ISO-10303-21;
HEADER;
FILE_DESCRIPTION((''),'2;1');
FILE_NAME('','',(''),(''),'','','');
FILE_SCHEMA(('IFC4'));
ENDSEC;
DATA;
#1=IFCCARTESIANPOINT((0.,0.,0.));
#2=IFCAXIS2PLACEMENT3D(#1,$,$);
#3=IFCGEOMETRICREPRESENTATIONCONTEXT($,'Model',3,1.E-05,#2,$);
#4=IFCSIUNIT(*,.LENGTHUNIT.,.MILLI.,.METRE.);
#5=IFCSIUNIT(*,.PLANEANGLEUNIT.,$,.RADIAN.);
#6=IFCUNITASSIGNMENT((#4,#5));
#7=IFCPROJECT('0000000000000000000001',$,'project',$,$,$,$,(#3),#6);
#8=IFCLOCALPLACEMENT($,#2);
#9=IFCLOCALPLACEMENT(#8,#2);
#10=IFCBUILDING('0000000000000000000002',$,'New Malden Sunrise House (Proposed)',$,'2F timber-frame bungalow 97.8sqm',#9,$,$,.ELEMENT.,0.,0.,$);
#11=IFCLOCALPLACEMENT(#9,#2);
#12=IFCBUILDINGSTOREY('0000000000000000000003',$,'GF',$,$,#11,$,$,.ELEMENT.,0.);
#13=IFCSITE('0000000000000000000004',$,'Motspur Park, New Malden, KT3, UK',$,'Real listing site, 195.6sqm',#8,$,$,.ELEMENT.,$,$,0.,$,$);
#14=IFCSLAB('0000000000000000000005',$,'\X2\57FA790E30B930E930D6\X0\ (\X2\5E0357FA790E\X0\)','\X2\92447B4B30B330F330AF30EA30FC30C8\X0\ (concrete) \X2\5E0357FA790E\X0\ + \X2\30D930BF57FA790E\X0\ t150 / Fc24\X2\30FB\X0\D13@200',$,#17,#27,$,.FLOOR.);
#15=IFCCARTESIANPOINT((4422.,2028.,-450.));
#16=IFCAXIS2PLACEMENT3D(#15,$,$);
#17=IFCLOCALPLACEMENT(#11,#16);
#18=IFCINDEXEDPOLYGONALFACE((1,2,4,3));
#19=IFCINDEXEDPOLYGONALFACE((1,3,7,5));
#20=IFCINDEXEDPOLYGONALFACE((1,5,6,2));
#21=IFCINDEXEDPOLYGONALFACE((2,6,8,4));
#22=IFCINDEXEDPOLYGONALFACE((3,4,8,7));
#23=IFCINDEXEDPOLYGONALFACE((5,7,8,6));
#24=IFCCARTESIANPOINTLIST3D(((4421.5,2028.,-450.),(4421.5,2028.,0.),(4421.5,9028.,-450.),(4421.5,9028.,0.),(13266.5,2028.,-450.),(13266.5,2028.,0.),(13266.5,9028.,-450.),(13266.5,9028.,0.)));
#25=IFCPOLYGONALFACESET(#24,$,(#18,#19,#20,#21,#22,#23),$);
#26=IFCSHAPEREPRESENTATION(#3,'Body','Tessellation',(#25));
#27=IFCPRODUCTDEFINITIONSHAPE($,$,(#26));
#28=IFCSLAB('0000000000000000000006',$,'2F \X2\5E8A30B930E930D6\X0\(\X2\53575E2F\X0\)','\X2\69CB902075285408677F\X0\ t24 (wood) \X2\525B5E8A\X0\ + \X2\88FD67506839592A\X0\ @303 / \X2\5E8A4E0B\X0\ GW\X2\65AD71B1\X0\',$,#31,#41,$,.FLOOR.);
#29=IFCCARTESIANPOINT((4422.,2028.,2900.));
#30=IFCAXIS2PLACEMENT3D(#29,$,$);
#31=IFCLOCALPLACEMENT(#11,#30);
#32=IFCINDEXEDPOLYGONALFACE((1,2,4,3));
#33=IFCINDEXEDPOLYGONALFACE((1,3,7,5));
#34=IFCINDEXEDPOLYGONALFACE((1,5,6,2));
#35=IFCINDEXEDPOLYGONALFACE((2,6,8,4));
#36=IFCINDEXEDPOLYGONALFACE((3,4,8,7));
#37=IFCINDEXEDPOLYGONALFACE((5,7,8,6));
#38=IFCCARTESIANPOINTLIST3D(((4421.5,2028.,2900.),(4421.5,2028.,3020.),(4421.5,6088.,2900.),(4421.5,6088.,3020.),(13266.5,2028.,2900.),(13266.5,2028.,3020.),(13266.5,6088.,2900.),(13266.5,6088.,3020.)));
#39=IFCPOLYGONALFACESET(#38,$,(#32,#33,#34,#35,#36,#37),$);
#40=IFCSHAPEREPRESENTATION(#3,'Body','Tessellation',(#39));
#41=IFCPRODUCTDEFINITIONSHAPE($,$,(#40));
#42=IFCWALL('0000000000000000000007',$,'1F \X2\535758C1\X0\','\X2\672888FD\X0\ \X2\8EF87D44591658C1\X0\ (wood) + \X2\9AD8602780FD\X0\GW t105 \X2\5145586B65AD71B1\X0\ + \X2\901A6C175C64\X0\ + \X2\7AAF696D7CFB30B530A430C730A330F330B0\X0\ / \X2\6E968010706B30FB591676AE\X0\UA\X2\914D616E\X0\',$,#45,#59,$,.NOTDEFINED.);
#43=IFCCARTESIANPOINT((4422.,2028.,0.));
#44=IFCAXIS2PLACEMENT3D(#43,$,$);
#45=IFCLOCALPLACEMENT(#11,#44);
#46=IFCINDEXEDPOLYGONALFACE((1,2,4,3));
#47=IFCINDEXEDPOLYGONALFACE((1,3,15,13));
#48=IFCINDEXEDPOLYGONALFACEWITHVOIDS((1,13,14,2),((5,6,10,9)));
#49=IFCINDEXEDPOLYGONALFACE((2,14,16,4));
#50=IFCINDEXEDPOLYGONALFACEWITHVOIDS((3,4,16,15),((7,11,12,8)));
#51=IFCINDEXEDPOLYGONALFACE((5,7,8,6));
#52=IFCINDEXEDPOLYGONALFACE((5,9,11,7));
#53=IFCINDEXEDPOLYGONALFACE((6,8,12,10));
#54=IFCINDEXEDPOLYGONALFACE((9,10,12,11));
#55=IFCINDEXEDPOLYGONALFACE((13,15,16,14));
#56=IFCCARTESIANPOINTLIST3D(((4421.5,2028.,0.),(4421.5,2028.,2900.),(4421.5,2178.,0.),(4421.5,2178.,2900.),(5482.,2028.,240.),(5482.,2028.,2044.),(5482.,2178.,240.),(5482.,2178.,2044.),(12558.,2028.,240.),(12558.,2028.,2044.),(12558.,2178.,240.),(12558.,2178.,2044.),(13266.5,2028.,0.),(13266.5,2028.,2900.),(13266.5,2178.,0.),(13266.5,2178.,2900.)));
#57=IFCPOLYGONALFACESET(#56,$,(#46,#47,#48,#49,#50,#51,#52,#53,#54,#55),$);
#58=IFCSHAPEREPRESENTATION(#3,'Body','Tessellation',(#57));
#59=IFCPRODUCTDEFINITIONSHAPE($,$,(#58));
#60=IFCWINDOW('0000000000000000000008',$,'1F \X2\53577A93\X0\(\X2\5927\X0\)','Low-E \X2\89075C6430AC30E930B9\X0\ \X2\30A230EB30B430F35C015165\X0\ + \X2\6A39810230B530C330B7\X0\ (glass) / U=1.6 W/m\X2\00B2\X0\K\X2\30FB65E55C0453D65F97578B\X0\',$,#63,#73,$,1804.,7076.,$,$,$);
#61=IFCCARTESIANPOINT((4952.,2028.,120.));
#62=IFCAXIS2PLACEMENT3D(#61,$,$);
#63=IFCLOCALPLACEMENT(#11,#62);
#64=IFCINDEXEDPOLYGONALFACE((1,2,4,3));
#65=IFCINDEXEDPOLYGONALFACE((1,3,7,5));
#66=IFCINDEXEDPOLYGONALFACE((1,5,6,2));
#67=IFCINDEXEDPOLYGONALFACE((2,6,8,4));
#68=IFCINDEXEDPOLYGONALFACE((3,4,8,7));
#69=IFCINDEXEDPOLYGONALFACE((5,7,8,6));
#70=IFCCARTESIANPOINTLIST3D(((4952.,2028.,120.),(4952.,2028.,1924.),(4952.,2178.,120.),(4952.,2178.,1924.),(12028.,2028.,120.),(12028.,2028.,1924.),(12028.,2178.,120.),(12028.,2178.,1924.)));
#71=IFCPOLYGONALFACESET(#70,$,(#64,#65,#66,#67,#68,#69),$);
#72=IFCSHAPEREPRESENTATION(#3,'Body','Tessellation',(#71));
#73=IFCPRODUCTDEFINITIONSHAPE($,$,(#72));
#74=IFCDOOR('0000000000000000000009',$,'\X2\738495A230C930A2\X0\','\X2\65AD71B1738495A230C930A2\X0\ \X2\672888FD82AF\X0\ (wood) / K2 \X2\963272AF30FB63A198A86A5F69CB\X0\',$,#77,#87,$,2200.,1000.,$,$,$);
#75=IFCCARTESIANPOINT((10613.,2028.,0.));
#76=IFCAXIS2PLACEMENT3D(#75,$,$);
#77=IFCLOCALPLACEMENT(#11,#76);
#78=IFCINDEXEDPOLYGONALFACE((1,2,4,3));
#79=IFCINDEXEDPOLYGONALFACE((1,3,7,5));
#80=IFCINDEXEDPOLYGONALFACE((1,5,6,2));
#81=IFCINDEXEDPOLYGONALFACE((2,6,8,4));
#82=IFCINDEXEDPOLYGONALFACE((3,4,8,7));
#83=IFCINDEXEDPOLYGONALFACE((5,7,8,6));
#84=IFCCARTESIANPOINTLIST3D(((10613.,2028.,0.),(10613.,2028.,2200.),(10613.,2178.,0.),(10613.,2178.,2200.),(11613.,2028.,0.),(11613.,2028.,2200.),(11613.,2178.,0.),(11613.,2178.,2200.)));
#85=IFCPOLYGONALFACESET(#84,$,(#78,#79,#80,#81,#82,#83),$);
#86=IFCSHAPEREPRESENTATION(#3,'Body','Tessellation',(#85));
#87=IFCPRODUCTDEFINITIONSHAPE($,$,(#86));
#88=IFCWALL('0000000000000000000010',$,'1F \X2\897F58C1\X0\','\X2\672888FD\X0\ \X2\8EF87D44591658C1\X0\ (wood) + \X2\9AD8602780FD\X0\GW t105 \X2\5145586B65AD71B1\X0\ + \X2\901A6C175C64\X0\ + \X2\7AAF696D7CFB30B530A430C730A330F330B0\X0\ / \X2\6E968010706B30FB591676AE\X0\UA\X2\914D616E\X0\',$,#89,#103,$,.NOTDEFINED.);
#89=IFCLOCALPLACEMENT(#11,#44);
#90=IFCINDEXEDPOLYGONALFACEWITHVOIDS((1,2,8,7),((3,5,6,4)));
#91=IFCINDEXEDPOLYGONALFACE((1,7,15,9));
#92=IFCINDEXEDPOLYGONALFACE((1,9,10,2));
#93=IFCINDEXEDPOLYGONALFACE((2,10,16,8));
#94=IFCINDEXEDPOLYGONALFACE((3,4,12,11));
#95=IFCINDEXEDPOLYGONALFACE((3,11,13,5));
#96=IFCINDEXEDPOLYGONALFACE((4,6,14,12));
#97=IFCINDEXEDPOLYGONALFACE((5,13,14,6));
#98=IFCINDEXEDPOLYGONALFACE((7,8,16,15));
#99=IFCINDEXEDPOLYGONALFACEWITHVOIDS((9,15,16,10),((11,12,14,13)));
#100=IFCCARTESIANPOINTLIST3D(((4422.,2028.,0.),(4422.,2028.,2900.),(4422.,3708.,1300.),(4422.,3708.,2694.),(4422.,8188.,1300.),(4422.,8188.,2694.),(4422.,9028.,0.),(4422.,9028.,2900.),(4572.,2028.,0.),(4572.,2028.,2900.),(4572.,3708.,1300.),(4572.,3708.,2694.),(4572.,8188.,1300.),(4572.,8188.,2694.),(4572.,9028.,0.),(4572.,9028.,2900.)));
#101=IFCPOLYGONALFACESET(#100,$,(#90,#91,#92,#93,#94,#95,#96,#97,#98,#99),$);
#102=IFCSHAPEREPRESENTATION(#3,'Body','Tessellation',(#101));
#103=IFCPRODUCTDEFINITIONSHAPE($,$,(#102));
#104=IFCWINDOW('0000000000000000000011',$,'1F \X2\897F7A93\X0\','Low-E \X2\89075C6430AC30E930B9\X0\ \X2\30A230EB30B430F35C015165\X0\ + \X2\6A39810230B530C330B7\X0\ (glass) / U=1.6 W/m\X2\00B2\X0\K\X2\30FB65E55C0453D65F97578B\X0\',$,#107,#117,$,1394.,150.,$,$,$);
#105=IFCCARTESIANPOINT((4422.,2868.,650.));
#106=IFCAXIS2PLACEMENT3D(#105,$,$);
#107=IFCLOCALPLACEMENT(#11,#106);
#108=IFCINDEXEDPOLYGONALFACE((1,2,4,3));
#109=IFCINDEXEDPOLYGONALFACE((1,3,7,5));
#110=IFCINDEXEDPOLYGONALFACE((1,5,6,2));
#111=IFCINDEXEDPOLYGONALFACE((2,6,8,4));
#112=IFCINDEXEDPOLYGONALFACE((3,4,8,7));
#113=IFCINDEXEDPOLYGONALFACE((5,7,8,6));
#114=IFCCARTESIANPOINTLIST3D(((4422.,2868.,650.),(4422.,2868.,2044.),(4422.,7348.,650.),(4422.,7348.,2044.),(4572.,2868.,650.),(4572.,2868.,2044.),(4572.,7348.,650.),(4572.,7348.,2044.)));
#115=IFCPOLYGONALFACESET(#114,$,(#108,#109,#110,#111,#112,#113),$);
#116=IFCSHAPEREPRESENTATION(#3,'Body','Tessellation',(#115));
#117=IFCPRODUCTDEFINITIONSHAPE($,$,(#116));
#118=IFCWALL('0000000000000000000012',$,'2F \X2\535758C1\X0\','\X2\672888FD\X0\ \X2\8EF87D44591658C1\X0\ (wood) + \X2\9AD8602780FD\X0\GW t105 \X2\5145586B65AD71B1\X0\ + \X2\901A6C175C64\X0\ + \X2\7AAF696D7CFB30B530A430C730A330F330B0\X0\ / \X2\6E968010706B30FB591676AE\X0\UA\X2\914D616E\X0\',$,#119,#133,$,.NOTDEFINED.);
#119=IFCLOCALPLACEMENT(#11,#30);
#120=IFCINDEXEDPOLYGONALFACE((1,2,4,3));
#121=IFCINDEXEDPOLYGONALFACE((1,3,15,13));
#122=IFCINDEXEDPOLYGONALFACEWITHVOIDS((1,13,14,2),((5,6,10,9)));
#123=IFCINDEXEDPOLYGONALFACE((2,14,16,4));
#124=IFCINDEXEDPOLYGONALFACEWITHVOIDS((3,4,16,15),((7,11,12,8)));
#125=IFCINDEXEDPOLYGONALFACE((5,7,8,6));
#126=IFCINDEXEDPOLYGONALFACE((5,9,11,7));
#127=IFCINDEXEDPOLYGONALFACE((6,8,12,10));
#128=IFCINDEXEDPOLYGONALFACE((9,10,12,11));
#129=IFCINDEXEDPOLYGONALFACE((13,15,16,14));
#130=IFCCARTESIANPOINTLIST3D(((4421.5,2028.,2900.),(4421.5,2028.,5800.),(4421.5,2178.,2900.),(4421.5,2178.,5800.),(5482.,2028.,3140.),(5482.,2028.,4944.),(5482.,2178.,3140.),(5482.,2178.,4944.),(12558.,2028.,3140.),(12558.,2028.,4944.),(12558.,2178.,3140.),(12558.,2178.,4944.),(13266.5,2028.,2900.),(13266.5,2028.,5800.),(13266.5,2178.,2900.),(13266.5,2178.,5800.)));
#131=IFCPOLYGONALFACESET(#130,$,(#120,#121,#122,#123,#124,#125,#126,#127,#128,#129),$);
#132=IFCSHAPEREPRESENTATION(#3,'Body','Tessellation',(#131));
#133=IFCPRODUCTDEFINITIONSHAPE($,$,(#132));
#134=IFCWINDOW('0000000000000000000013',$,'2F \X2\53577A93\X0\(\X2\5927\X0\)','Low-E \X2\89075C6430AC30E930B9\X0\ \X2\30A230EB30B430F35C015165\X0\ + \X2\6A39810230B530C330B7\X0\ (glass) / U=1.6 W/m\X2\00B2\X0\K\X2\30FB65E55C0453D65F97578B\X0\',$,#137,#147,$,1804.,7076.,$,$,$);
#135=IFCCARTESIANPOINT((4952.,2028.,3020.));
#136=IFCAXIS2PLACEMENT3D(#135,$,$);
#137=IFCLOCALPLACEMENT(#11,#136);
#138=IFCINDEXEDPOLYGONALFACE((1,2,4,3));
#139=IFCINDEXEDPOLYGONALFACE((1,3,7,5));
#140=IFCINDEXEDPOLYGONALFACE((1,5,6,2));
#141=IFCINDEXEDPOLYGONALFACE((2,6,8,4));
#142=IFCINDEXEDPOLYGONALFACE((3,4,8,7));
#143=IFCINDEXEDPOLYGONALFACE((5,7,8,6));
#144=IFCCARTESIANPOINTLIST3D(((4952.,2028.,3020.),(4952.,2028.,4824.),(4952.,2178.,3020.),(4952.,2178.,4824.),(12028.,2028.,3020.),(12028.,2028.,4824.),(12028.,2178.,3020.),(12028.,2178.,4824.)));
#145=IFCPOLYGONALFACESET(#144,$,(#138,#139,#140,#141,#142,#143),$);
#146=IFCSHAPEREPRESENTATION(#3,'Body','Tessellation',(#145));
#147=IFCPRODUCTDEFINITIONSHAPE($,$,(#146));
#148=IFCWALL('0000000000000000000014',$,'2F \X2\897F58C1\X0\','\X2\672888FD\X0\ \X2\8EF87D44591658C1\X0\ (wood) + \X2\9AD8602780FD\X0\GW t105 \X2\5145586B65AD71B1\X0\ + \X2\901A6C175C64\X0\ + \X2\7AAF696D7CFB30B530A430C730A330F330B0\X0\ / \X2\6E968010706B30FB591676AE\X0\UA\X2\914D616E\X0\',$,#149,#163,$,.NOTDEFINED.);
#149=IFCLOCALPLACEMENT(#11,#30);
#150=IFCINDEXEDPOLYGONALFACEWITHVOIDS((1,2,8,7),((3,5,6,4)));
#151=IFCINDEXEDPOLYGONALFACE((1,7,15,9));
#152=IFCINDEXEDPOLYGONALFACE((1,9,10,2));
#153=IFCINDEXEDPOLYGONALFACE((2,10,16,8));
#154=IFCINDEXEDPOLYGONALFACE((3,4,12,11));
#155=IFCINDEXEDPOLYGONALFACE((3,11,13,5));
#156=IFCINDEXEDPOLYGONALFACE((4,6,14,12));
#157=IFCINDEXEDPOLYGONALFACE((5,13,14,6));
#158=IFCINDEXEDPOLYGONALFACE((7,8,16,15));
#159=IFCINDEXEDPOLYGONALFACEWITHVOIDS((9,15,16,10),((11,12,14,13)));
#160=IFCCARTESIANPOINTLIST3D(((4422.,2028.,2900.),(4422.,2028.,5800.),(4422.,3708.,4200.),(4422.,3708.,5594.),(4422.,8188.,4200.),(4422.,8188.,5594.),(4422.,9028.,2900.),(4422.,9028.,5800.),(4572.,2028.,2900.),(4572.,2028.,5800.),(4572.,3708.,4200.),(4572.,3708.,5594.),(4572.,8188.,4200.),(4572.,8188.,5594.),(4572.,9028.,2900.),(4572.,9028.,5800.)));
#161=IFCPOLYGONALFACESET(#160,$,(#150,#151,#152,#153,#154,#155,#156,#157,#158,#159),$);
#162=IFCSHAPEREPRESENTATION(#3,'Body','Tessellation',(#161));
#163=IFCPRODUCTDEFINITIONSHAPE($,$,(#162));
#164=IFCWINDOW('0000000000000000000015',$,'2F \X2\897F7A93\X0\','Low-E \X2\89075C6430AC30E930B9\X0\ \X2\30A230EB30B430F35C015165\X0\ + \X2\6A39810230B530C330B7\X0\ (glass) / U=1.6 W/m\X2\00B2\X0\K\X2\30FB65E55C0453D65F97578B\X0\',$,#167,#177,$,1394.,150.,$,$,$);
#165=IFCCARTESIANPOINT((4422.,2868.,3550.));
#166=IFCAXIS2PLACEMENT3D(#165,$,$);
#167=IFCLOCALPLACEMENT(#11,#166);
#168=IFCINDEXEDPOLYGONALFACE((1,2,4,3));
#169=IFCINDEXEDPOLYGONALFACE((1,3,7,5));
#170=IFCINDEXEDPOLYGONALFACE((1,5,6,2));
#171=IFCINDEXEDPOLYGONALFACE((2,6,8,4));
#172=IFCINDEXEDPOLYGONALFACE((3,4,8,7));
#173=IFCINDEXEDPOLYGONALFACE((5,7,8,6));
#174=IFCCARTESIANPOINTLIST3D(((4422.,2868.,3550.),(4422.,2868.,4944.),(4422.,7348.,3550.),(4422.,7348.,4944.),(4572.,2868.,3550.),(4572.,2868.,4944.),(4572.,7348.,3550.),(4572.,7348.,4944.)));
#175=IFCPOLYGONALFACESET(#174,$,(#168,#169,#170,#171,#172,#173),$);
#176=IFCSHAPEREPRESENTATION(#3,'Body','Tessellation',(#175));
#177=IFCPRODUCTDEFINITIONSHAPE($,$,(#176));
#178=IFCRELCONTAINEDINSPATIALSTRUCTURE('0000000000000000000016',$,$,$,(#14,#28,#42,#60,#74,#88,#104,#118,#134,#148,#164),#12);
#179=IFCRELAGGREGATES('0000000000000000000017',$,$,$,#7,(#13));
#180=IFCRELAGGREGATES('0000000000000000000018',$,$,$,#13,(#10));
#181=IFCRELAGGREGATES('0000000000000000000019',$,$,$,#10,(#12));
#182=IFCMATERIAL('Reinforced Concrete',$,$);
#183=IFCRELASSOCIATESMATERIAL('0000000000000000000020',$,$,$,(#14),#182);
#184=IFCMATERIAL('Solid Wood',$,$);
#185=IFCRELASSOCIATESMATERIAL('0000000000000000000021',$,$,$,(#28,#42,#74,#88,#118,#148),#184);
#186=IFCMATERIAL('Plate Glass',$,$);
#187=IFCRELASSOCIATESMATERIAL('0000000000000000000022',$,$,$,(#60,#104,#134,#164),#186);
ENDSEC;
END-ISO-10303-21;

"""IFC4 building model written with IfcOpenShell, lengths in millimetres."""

from ifc_helpers import new_model, si_unit, frame, frame_2d, origin, place, context, project, spatial, rectangle, extrude, material, element, fill, save


model = new_model("IFC4")

# Units and contexts
model_context = context("Model", 3, precision=1e-05, world=origin())
ifc_project = project(units=[si_unit("LENGTHUNIT", "METRE", prefix="MILLI"), si_unit("PLANEANGLEUNIT", "RADIAN")], contexts=[model_context])

# Site, building, storey
site_placement = place(None, origin())
site = spatial("IfcSite", under=ifc_project, at=site_placement, Name="Motspur Park, New Malden, KT3, UK", ObjectType="Real listing site, 195.6sqm", CompositionType="ELEMENT", RefElevation=0.0)
building_placement = place(site_placement, origin())
building = spatial("IfcBuilding", under=site, at=building_placement, Name="New Malden Sunrise House (Proposed)", ObjectType="2F timber-frame bungalow 97.8sqm", CompositionType="ELEMENT", ElevationOfRefHeight=0.0, ElevationOfTerrain=0.0)
storey_placement = place(building_placement, origin())
storey = spatial("IfcBuildingStorey", under=building, at=storey_placement, Name="GF", CompositionType="ELEMENT", Elevation=0.0)

# Slabs
ifc_material_1 = material(Name="Reinforced Concrete")
slab_1_placement = place(storey_placement, frame((4422.0, 2028.0, -450.0)))
element("IfcSlab", 1, at=slab_1_placement, inside=storey, material=ifc_material_1, Name="基礎スラブ (布基礎)", Description="鉄筋コンクリート (concrete) 布基礎 + ベタ基礎 t150 / Fc24・D13@200", PredefinedType="FLOOR", context=model_context, shape_type="SweptSolid", body=[
    extrude(rectangle(XDim=8845.0, YDim=7000.0, at=frame_2d((4422.0, 3500.0))), frame((4422.0, 2028.0, -450.0)), (0.0, 0.0, 1.0), 450.0),
])
ifc_material_2 = material(Name="Solid Wood")
slab_2_placement = place(storey_placement, frame((4422.0, 2028.0, 2900.0)))
element("IfcSlab", 2, at=slab_2_placement, inside=storey, material=ifc_material_2, Name="2F 床スラブ(南帯)", Description="構造用合板 t24 (wood) 剛床 + 製材根太 @303 / 床下 GW断熱", PredefinedType="FLOOR", context=model_context, shape_type="SweptSolid", body=[
    extrude(rectangle(XDim=8845.0, YDim=4060.0, at=frame_2d((4422.0, 2030.0))), frame((4422.0, 2028.0, 2900.0)), (0.0, 0.0, 1.0), 120.0),
])

# Wall, openings, window, door
wall_1_placement = place(storey_placement, frame((4422.0, 2028.0, 0.0)))
wall_1 = element("IfcWall", 3, at=wall_1_placement, inside=storey, material=ifc_material_2, Name="1F 南壁", Description="木製 軸組外壁 (wood) + 高性能GW t105 充填断熱 + 通気層 + 窯業系サイディング / 準耐火・外皮UA配慮", PredefinedType="NOTDEFINED", context=model_context, shape_type="SweptSolid", body=[
    extrude(rectangle(XDim=8845.0, YDim=150.0, at=frame_2d((4422.0, 75.0))), frame((4422.0, 2028.0, 0.0)), (0.0, 0.0, 1.0), 2900.0),
])
opening_1_placement = place(storey_placement, frame((4952.0, 2028.0, 120.0)))
opening_1 = element("IfcOpeningElement", 4, at=opening_1_placement, cuts=wall_1, PredefinedType="NOTDEFINED", context=model_context, shape_type="SweptSolid", body=[
    extrude(rectangle(XDim=7076.0, YDim=150.0, at=frame_2d((3538.0, 75.0))), frame((4952.0, 2028.0, 120.0)), (0.0, 0.0, 1.0), 1804.0),
])
opening_2_placement = place(storey_placement, frame((10613.0, 2028.0, 0.0)))
opening_2 = element("IfcOpeningElement", 5, at=opening_2_placement, cuts=wall_1, PredefinedType="NOTDEFINED", context=model_context, shape_type="SweptSolid", body=[
    extrude(rectangle(XDim=1000.0, YDim=150.0, at=frame_2d((500.0, 75.0))), frame((10613.0, 2028.0, 0.0)), (0.0, 0.0, 1.0), 2200.0),
])
ifc_material_3 = material(Name="Plate Glass")
window_1_placement = place(storey_placement, frame((4952.0, 2028.0, 120.0)))
window_1 = element("IfcWindow", 6, at=window_1_placement, inside=storey, material=ifc_material_3, Name="1F 南窓(大)", Description="Low-E 複層ガラス アルゴン封入 + 樹脂サッシ (glass) / U=1.6 W/m²K・日射取得型", OverallHeight=1804.0, OverallWidth=7076.0, context=model_context, shape_type="SweptSolid", body=[
    extrude(rectangle(XDim=7076.0, YDim=150.0, at=frame_2d((3538.0, 75.0))), frame((4952.0, 2028.0, 120.0)), (0.0, 0.0, 1.0), 1804.0),
])
fill(opening_1, window_1)
door_placement = place(storey_placement, frame((10613.0, 2028.0, 0.0)))
door = element("IfcDoor", 7, at=door_placement, inside=storey, material=ifc_material_2, Name="玄関ドア", Description="断熱玄関ドア 木製芯 (wood) / K2 防犯・採風機構", OverallHeight=2200.0, OverallWidth=1000.0, context=model_context, shape_type="SweptSolid", body=[
    extrude(rectangle(XDim=1000.0, YDim=150.0, at=frame_2d((500.0, 75.0))), frame((10613.0, 2028.0, 0.0)), (0.0, 0.0, 1.0), 2200.0),
])
fill(opening_2, door)

# Wall, opening, window
wall_2_placement = place(storey_placement, frame((4422.0, 2028.0, 0.0)))
wall_2 = element("IfcWall", 8, at=wall_2_placement, inside=storey, material=ifc_material_2, Name="1F 西壁", Description="木製 軸組外壁 (wood) + 高性能GW t105 充填断熱 + 通気層 + 窯業系サイディング / 準耐火・外皮UA配慮", PredefinedType="NOTDEFINED", context=model_context, shape_type="SweptSolid", body=[
    extrude(rectangle(XDim=150.0, YDim=7000.0, at=frame_2d((75.0, 3500.0))), frame((4422.0, 2028.0, 0.0)), (0.0, 0.0, 1.0), 2900.0),
])
opening_3_placement = place(storey_placement, frame((4422.0, 2868.0, 650.0)))
opening_3 = element("IfcOpeningElement", 9, at=opening_3_placement, cuts=wall_2, PredefinedType="NOTDEFINED", context=model_context, shape_type="SweptSolid", body=[
    extrude(rectangle(XDim=150.0, YDim=4480.0, at=frame_2d((75.0, 2240.0))), frame((4422.0, 2868.0, 650.0)), (0.0, 0.0, 1.0), 1394.0),
])
window_2_placement = place(storey_placement, frame((4422.0, 2868.0, 650.0)))
window_2 = element("IfcWindow", 10, at=window_2_placement, inside=storey, material=ifc_material_3, Name="1F 西窓", Description="Low-E 複層ガラス アルゴン封入 + 樹脂サッシ (glass) / U=1.6 W/m²K・日射取得型", OverallHeight=1394.0, OverallWidth=150.0, context=model_context, shape_type="SweptSolid", body=[
    extrude(rectangle(XDim=150.0, YDim=4480.0, at=frame_2d((75.0, 2240.0))), frame((4422.0, 2868.0, 650.0)), (0.0, 0.0, 1.0), 1394.0),
])
fill(opening_3, window_2)

# Walls, openings, windows
wall_3_placement = place(storey_placement, frame((4422.0, 2028.0, 2900.0)))
wall_3 = element("IfcWall", 11, at=wall_3_placement, inside=storey, material=ifc_material_2, Name="2F 南壁", Description="木製 軸組外壁 (wood) + 高性能GW t105 充填断熱 + 通気層 + 窯業系サイディング / 準耐火・外皮UA配慮", PredefinedType="NOTDEFINED", context=model_context, shape_type="SweptSolid", body=[
    extrude(rectangle(XDim=8845.0, YDim=150.0, at=frame_2d((4422.0, 75.0))), frame((4422.0, 2028.0, 2900.0)), (0.0, 0.0, 1.0), 2900.0),
])
opening_4_placement = place(storey_placement, frame((4952.0, 2028.0, 3020.0)))
opening_4 = element("IfcOpeningElement", 12, at=opening_4_placement, cuts=wall_3, PredefinedType="NOTDEFINED", context=model_context, shape_type="SweptSolid", body=[
    extrude(rectangle(XDim=7076.0, YDim=150.0, at=frame_2d((3538.0, 75.0))), frame((4952.0, 2028.0, 3020.0)), (0.0, 0.0, 1.0), 1804.0),
])
window_3_placement = place(storey_placement, frame((4952.0, 2028.0, 3020.0)))
window_3 = element("IfcWindow", 13, at=window_3_placement, inside=storey, material=ifc_material_3, Name="2F 南窓(大)", Description="Low-E 複層ガラス アルゴン封入 + 樹脂サッシ (glass) / U=1.6 W/m²K・日射取得型", OverallHeight=1804.0, OverallWidth=7076.0, context=model_context, shape_type="SweptSolid", body=[
    extrude(rectangle(XDim=7076.0, YDim=150.0, at=frame_2d((3538.0, 75.0))), frame((4952.0, 2028.0, 3020.0)), (0.0, 0.0, 1.0), 1804.0),
])
fill(opening_4, window_3)
wall_4_placement = place(storey_placement, frame((4422.0, 2028.0, 2900.0)))
wall_4 = element("IfcWall", 14, at=wall_4_placement, inside=storey, material=ifc_material_2, Name="2F 西壁", Description="木製 軸組外壁 (wood) + 高性能GW t105 充填断熱 + 通気層 + 窯業系サイディング / 準耐火・外皮UA配慮", PredefinedType="NOTDEFINED", context=model_context, shape_type="SweptSolid", body=[
    extrude(rectangle(XDim=150.0, YDim=7000.0, at=frame_2d((75.0, 3500.0))), frame((4422.0, 2028.0, 2900.0)), (0.0, 0.0, 1.0), 2900.0),
])
opening_5_placement = place(storey_placement, frame((4422.0, 2868.0, 3550.0)))
opening_5 = element("IfcOpeningElement", 15, at=opening_5_placement, cuts=wall_4, PredefinedType="NOTDEFINED", context=model_context, shape_type="SweptSolid", body=[
    extrude(rectangle(XDim=150.0, YDim=4480.0, at=frame_2d((75.0, 2240.0))), frame((4422.0, 2868.0, 3550.0)), (0.0, 0.0, 1.0), 1394.0),
])
window_4_placement = place(storey_placement, frame((4422.0, 2868.0, 3550.0)))
window_4 = element("IfcWindow", 16, at=window_4_placement, inside=storey, material=ifc_material_3, Name="2F 西窓", Description="Low-E 複層ガラス アルゴン封入 + 樹脂サッシ (glass) / U=1.6 W/m²K・日射取得型", OverallHeight=1394.0, OverallWidth=150.0, context=model_context, shape_type="SweptSolid", body=[
    extrude(rectangle(XDim=150.0, YDim=4480.0, at=frame_2d((75.0, 2240.0))), frame((4422.0, 2868.0, 3550.0)), (0.0, 0.0, 1.0), 1394.0),
])
fill(opening_5, window_4)

save(model, "model.ifc")
